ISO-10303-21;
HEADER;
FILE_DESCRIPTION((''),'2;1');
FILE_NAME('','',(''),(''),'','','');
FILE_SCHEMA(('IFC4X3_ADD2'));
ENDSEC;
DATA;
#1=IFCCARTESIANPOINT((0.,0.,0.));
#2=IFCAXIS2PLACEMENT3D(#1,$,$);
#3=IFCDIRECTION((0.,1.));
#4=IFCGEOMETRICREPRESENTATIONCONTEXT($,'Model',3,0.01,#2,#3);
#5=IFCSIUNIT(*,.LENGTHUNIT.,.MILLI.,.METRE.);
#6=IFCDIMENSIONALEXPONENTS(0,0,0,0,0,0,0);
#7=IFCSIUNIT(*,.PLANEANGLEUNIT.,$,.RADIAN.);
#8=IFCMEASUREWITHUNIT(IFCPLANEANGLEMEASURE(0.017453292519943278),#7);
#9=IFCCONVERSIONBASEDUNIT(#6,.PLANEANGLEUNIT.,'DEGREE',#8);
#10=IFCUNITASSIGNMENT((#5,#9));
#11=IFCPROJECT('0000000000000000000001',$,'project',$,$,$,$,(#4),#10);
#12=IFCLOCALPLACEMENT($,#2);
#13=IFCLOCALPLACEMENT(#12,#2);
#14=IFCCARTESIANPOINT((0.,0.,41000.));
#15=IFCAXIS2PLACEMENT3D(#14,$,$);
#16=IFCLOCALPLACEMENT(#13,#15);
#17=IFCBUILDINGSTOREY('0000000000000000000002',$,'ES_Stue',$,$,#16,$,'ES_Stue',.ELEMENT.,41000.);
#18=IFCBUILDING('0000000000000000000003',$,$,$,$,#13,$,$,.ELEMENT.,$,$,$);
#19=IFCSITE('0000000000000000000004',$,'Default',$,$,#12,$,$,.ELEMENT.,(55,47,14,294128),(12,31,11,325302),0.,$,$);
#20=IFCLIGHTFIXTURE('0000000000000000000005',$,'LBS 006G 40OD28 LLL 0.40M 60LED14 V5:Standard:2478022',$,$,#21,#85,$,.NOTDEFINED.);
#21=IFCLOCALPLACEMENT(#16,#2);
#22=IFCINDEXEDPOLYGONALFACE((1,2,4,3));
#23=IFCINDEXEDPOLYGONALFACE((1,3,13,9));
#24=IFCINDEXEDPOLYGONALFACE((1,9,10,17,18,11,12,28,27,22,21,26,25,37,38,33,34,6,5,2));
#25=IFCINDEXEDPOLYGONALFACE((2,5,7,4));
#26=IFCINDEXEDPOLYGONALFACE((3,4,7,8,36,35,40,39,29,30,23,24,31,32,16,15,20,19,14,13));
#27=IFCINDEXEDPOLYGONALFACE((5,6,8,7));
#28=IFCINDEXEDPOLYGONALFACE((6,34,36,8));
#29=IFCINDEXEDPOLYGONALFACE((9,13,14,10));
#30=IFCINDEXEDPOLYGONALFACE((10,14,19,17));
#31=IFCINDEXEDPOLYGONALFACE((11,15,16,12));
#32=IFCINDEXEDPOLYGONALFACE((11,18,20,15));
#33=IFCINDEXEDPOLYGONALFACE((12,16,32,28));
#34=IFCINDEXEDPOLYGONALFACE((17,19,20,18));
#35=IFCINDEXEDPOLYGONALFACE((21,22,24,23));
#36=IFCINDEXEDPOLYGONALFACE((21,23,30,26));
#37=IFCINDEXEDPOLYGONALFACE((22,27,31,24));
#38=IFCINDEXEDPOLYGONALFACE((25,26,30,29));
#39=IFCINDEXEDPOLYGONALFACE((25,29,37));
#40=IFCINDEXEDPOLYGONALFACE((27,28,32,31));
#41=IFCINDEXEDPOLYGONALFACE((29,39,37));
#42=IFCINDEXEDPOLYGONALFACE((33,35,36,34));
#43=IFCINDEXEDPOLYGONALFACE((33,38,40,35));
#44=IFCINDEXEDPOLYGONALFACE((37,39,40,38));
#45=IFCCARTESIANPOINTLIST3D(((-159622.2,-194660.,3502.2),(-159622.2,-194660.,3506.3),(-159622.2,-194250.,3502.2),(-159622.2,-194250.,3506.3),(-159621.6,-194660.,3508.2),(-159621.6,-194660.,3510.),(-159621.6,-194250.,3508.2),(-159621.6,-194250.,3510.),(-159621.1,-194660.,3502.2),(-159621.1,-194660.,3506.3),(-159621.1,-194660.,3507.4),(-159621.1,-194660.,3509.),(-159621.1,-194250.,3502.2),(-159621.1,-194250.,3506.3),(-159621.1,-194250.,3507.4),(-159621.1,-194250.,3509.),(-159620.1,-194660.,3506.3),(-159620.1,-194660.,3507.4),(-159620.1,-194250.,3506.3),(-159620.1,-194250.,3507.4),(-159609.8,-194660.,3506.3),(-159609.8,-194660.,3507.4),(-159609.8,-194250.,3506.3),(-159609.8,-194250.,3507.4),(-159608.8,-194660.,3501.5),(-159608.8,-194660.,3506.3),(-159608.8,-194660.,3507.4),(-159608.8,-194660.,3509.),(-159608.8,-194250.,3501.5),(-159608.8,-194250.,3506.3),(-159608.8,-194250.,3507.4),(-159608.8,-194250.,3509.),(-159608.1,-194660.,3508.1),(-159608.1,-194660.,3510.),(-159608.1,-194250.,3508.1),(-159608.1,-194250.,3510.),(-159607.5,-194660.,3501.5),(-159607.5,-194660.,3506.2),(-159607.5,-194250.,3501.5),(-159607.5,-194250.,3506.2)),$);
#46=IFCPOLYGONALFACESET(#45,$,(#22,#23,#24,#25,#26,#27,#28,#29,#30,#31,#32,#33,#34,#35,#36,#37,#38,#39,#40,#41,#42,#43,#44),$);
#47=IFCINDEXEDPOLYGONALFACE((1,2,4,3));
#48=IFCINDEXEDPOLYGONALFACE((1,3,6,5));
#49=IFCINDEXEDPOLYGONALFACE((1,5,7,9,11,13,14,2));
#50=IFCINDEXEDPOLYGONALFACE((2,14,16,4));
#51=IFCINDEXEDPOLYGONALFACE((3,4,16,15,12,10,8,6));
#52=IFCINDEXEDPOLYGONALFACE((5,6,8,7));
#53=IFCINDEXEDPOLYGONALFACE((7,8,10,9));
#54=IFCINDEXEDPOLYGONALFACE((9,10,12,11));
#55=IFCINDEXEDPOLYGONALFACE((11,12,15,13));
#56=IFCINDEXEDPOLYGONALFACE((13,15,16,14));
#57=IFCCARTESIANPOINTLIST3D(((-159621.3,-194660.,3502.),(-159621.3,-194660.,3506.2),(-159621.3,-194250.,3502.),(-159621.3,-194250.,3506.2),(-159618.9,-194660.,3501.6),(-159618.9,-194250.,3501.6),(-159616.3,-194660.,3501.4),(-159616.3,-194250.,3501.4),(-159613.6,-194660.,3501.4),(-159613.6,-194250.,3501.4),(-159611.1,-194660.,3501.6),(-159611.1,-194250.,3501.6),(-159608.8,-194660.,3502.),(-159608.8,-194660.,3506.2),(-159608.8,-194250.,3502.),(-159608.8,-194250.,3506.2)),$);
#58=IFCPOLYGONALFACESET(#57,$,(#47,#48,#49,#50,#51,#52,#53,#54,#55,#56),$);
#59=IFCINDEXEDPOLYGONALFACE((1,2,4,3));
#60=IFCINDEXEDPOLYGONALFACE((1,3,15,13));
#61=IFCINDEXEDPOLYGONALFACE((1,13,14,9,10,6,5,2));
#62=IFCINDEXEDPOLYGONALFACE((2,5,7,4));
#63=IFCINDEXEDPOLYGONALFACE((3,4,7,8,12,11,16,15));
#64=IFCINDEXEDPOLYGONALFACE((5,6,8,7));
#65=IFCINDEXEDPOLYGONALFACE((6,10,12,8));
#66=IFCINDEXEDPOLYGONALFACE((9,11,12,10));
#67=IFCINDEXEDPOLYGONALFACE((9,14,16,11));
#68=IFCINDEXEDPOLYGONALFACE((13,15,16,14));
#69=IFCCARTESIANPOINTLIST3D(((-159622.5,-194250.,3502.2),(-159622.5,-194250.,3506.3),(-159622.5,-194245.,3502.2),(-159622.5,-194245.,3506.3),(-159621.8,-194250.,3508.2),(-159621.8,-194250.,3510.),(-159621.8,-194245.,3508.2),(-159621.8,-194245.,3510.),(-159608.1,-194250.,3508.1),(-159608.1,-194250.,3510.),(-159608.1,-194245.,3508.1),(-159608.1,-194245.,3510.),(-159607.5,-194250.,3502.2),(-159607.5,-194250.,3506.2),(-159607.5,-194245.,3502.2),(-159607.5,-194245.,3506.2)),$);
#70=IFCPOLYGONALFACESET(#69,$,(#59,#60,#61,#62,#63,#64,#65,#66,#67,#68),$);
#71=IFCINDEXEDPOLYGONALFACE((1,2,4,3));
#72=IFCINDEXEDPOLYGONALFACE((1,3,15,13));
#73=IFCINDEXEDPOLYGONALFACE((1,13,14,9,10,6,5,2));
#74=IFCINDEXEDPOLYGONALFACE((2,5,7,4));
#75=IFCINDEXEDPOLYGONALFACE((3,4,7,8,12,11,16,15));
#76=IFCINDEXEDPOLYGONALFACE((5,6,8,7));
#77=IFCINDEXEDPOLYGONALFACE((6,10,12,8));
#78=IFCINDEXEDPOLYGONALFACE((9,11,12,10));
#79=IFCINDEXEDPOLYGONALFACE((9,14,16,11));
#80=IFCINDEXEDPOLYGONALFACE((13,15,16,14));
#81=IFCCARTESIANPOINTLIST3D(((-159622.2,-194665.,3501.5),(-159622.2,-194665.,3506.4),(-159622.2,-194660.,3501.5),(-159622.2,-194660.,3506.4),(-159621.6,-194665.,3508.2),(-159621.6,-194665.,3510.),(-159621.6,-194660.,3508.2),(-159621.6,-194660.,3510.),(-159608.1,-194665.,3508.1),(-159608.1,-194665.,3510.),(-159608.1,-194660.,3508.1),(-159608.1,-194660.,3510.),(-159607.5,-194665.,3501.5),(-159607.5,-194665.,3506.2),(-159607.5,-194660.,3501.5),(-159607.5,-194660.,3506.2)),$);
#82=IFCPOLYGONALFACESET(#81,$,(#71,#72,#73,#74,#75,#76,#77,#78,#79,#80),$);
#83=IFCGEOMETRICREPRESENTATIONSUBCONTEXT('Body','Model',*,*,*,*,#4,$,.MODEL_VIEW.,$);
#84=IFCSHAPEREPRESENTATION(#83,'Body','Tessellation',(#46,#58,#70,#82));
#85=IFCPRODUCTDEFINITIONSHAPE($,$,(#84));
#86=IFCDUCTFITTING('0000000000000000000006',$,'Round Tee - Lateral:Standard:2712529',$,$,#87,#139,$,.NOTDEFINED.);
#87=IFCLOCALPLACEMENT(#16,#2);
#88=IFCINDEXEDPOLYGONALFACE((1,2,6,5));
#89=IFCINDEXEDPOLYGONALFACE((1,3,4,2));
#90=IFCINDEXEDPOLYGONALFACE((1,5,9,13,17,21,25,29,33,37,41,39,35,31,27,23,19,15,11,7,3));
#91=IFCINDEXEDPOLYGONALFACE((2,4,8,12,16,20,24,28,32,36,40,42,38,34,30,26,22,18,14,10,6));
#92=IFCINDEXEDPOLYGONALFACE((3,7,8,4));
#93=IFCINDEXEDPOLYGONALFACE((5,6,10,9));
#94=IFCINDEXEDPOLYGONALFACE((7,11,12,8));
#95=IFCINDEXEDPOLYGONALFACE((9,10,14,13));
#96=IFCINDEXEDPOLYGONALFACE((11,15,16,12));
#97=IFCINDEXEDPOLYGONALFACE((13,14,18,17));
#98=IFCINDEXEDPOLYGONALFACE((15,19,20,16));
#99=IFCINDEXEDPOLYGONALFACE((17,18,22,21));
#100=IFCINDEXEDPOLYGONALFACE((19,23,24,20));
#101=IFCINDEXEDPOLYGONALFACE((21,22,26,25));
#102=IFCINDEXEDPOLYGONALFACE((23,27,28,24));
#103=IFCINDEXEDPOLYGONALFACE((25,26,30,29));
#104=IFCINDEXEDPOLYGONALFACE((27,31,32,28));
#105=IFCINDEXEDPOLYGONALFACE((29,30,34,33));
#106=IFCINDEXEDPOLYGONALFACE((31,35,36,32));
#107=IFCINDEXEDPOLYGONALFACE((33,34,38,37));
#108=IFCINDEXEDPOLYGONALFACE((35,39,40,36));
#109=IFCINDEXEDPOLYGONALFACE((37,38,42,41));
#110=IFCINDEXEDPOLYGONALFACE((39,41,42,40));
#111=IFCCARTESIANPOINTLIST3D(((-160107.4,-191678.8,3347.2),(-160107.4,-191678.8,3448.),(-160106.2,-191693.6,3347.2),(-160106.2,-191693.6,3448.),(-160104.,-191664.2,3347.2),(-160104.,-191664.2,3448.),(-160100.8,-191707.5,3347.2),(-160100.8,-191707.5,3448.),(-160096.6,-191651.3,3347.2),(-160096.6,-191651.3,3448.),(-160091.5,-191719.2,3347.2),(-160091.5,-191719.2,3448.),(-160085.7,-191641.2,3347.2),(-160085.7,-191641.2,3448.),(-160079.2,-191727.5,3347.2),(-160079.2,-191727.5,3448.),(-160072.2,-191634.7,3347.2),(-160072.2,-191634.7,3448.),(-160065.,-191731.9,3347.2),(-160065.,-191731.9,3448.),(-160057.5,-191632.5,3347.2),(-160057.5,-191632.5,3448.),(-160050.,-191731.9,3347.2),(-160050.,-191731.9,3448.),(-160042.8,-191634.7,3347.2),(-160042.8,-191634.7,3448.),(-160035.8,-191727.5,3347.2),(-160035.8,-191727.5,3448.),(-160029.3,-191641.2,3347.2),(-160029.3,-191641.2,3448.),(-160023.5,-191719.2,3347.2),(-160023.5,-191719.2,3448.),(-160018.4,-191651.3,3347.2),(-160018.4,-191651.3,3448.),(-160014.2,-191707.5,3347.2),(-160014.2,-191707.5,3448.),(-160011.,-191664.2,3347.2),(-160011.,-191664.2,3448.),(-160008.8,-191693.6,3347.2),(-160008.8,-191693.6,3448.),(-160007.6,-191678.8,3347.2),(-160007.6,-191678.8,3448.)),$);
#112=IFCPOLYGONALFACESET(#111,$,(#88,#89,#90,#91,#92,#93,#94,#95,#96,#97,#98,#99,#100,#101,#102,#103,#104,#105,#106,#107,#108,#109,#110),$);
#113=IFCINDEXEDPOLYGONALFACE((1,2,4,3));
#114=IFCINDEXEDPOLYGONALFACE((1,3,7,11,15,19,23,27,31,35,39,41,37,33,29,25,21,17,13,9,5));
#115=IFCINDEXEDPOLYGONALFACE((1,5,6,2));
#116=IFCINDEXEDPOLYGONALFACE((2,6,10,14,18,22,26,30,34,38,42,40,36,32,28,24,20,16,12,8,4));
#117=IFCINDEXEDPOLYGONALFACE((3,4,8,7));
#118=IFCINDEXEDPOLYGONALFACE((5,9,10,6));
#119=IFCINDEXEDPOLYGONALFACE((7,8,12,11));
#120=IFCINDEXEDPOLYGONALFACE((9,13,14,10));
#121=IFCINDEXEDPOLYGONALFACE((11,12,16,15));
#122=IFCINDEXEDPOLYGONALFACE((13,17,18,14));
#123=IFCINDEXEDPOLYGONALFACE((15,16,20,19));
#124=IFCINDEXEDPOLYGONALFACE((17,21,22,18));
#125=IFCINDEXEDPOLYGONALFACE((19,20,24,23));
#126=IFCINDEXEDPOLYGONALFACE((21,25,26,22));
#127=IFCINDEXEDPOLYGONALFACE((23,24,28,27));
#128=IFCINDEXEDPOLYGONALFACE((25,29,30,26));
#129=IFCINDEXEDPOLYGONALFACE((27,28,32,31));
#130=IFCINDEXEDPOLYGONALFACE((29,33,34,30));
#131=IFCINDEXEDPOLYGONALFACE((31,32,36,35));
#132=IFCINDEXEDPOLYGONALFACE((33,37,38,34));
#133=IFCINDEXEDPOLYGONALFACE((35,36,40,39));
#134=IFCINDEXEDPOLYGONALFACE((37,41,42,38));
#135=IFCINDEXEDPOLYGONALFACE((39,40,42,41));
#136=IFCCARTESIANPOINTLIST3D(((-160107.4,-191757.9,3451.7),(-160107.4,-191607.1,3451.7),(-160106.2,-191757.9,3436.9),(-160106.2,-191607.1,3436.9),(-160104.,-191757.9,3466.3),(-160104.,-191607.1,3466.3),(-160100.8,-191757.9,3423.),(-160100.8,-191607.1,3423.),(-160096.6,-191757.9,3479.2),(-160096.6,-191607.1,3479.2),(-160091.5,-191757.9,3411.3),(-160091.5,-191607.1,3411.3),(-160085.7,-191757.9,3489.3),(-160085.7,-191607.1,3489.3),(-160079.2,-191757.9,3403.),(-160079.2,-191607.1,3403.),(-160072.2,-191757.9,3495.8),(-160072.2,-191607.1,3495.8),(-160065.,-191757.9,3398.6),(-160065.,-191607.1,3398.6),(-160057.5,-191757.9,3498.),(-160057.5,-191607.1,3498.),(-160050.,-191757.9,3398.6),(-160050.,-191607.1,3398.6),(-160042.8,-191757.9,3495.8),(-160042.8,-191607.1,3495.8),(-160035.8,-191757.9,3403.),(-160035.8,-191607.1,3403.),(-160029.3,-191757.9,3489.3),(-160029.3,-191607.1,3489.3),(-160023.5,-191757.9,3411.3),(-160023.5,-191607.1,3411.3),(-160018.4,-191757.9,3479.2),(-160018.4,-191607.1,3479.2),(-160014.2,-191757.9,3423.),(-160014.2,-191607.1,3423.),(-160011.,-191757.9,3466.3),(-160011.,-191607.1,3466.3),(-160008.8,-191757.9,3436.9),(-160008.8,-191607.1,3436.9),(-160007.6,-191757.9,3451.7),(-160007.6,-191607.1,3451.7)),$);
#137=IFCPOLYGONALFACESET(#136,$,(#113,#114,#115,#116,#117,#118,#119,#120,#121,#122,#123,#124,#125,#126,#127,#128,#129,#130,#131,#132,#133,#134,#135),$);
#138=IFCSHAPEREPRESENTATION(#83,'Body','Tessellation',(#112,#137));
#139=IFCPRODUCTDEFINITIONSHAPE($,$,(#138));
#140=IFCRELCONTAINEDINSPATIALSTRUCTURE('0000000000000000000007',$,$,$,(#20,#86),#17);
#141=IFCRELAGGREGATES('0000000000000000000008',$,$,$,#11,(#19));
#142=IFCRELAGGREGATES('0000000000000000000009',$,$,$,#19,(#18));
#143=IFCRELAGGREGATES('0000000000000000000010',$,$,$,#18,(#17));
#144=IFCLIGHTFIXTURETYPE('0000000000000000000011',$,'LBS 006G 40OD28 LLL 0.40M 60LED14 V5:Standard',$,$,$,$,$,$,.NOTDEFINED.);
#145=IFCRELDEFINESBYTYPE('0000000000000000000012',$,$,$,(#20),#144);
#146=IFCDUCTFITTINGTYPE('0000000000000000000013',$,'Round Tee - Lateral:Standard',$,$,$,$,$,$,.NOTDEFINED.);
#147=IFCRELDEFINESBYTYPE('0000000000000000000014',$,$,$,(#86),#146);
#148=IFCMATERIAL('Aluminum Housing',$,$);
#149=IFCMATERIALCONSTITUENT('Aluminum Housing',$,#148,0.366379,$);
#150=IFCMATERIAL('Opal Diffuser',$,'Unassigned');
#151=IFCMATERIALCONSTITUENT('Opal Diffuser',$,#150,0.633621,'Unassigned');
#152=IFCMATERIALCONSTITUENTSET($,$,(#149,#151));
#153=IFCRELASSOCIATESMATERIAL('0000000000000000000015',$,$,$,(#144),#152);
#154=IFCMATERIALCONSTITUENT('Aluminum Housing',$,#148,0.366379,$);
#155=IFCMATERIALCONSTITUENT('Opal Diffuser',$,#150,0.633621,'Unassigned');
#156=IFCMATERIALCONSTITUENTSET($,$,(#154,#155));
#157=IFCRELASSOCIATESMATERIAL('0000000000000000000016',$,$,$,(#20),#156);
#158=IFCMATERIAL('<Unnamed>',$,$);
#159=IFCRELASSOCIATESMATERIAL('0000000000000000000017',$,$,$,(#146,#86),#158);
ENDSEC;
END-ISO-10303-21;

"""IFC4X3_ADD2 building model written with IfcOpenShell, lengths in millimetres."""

from ifc_helpers import new_model, entity, si_unit, converted_unit, direction, frame, frame_2d, origin, place, context, subcontext, project, spatial, polyline, circle, outline, extrude, source, transform, mapped, material, constituent, constituent_set, type_object, type_shapes, element, save


model = new_model("IFC4X3_ADD2")

# Units and contexts
model_context = context("Model", 3, precision=0.01, world=origin(), true_north=direction((0.0, 1.0)))
body_context = subcontext(model_context, "Body", "Model", "MODEL_VIEW")
ifc_project = project(units=[si_unit("LENGTHUNIT", "METRE", prefix="MILLI"), converted_unit("PLANEANGLEUNIT", "DEGREE", entity("IfcPlaneAngleMeasure", 0.017453292519943278), si_unit("PLANEANGLEUNIT", "RADIAN"), dimensions=[0, 0, 0, 0, 0, 0, 0])], contexts=[model_context])

# Site, building, storey
site_placement = place(None, origin())
site = spatial("IfcSite", under=ifc_project, at=site_placement, Name="Default", CompositionType="ELEMENT", RefLatitude=(55, 47, 14, 294128), RefLongitude=(12, 31, 11, 325302), RefElevation=0.0)
building_placement = place(site_placement, origin())
building = spatial("IfcBuilding", under=site, at=building_placement, CompositionType="ELEMENT")
storey_placement = place(building_placement, frame((0.0, 0.0, 41000.0)))
storey = spatial("IfcBuildingStorey", under=building, at=storey_placement, Name="ES_Stue", LongName="ES_Stue", CompositionType="ELEMENT", Elevation=41000.0)

# Shared definitions
ifc_material_1 = material(Name="<Unnamed>")

# Light fixture
ifc_material_2 = material(Name="Aluminum Housing")
ifc_material_3 = material(Name="Opal Diffuser", Category="Unassigned")
ifc_constituent_1 = constituent(ifc_material_2, Name="Aluminum Housing", fraction=0.366379)
ifc_constituent_2 = constituent(ifc_material_3, Name="Opal Diffuser", Category="Unassigned", fraction=0.633621)
ifc_constituent_set_1 = constituent_set(constituents=[ifc_constituent_1, ifc_constituent_2])
light_fixture_type = type_object("IfcLightFixtureType", Name="LBS 006G 40OD28 LLL 0.40M 60LED14 V5:Standard", PredefinedType="NOTDEFINED", material=ifc_constituent_set_1)
shared_shape_1 = source(origin(), body_context, "Body", "SweptSolid", [
    extrude(outline(polyline([(-5.0, -6.1), (-5.0, -7.4), (-0.3, -7.4), (1.7, -6.8), (3.5, -6.8), (3.5, 6.7), (1.8, 6.7), (-0.1, 7.3), (-4.2, 7.3), (-4.2, 6.2), (-0.1, 6.2), (-0.1, 5.2), (0.9, 5.2), (0.9, 6.2), (2.5, 6.2), (2.5, -6.1), (0.9, -6.1), (0.9, -5.1), (-0.1, -5.1), (-0.1, -6.1), (-5.0, -6.1)])), frame((-205.0, 0.1, 3.5), z_axis=(-1.0, 0.0, 0.0), x_axis=(0.0, 0.0, -1.0)), (0.0, 0.0, -1.0), 410.0),
    extrude(outline(polyline([(-0.8, -6.2), (3.4, -6.2), (3.4, 6.2), (-0.8, 6.2), (-1.2, 3.9), (-1.4, 1.4), (-1.4, -1.3), (-1.2, -3.9), (-0.8, -6.2)])), frame((-205.0, 0.0, 7.2), z_axis=(1.0, 0.0, 0.0), x_axis=(0.0, 0.0, -1.0)), (0.0, 0.0, 1.0), 410.0),
    extrude(outline(polyline([(-4.4, -7.5), (-0.3, -7.5), (1.5, -6.8), (3.3, -6.8), (3.3, 6.9), (1.5, 6.9), (-0.5, 7.4), (-4.4, 7.4), (-4.4, -7.5)])), frame((205.0, 0.0, 3.3), z_axis=(1.0, 0.0, 0.0), x_axis=(0.0, 0.0, -1.0)), (0.0, 0.0, 1.0), 5.0),
    extrude(outline(polyline([(-5.0, -7.4), (-0.1, -7.4), (1.7, -6.7), (3.5, -6.7), (3.5, 6.8), (1.6, 6.8), (-0.3, 7.3), (-5.0, 7.3), (-5.0, -7.4)])), frame((-210.0, 0.2, 3.5), z_axis=(1.0, 0.0, 0.0), x_axis=(0.0, 0.0, -1.0)), (0.0, 0.0, 1.0), 5.0),
])
type_shapes(light_fixture_type, [shared_shape_1])
ifc_constituent_3 = constituent(ifc_material_2, Name="Aluminum Housing", fraction=0.366379)
ifc_constituent_4 = constituent(ifc_material_3, Name="Opal Diffuser", Category="Unassigned", fraction=0.633621)
ifc_constituent_set_2 = constituent_set(constituents=[ifc_constituent_3, ifc_constituent_4])
light_fixture_1_placement = place(storey_placement, frame((-159615.0, -194455.0, 3510.0), z_axis=(0.0, 0.0, -1.0), x_axis=(0.0, 1.0, 0.0)))
element("IfcLightFixture", 1, at=light_fixture_1_placement, inside=storey, type_object=light_fixture_type, material=ifc_constituent_set_2, Name="LBS 006G 40OD28 LLL 0.40M 60LED14 V5:Standard:2478022", PredefinedType="NOTDEFINED", context=body_context, shape_type="MappedRepresentation", body=[
    mapped(shared_shape_1, transform((0.0, 0.0, 0.0), scale=1.0)),
])

# Duct fitting
duct_fitting_type = type_object("IfcDuctFittingType", Name="Round Tee - Lateral:Standard", PredefinedType="NOTDEFINED", material=ifc_material_1)
shared_shape_2 = source(origin(), body_context, "Body", "SweptSolid", [
    extrude(circle(Radius=50.0, at=frame_2d((0.0, 0.0), x_axis=(1.0, 0.0))), frame((0.0, -100.8, 0.0), z_axis=(0.0, 1.0, 0.0), x_axis=(1.0, 0.0, 0.0)), (0.0, 0.0, 1.0), 100.8),
    extrude(circle(Radius=50.0, at=frame_2d((0.0, 0.0), x_axis=(1.0, 0.0))), frame((-75.4, 0.0, 0.0), z_axis=(1.0, 0.0, 0.0), x_axis=(0.0, 1.0, 0.0)), (0.0, 0.0, 1.0), 150.8),
])
type_shapes(duct_fitting_type, [shared_shape_2])
duct_fitting_placement = place(storey_placement, frame((-160057.5, -191682.5, 3448.0), z_axis=(1.0, 0.0, 0.0), x_axis=(0.0, 1.0, 0.0)))
element("IfcDuctFitting", 2, at=duct_fitting_placement, inside=storey, type_object=duct_fitting_type, material=ifc_material_1, Name="Round Tee - Lateral:Standard:2712529", PredefinedType="NOTDEFINED", context=body_context, shape_type="MappedRepresentation", body=[
    mapped(shared_shape_2, transform((0.0, 0.0, 0.0), scale=1.0)),
])

save(model, "model.ifc")
